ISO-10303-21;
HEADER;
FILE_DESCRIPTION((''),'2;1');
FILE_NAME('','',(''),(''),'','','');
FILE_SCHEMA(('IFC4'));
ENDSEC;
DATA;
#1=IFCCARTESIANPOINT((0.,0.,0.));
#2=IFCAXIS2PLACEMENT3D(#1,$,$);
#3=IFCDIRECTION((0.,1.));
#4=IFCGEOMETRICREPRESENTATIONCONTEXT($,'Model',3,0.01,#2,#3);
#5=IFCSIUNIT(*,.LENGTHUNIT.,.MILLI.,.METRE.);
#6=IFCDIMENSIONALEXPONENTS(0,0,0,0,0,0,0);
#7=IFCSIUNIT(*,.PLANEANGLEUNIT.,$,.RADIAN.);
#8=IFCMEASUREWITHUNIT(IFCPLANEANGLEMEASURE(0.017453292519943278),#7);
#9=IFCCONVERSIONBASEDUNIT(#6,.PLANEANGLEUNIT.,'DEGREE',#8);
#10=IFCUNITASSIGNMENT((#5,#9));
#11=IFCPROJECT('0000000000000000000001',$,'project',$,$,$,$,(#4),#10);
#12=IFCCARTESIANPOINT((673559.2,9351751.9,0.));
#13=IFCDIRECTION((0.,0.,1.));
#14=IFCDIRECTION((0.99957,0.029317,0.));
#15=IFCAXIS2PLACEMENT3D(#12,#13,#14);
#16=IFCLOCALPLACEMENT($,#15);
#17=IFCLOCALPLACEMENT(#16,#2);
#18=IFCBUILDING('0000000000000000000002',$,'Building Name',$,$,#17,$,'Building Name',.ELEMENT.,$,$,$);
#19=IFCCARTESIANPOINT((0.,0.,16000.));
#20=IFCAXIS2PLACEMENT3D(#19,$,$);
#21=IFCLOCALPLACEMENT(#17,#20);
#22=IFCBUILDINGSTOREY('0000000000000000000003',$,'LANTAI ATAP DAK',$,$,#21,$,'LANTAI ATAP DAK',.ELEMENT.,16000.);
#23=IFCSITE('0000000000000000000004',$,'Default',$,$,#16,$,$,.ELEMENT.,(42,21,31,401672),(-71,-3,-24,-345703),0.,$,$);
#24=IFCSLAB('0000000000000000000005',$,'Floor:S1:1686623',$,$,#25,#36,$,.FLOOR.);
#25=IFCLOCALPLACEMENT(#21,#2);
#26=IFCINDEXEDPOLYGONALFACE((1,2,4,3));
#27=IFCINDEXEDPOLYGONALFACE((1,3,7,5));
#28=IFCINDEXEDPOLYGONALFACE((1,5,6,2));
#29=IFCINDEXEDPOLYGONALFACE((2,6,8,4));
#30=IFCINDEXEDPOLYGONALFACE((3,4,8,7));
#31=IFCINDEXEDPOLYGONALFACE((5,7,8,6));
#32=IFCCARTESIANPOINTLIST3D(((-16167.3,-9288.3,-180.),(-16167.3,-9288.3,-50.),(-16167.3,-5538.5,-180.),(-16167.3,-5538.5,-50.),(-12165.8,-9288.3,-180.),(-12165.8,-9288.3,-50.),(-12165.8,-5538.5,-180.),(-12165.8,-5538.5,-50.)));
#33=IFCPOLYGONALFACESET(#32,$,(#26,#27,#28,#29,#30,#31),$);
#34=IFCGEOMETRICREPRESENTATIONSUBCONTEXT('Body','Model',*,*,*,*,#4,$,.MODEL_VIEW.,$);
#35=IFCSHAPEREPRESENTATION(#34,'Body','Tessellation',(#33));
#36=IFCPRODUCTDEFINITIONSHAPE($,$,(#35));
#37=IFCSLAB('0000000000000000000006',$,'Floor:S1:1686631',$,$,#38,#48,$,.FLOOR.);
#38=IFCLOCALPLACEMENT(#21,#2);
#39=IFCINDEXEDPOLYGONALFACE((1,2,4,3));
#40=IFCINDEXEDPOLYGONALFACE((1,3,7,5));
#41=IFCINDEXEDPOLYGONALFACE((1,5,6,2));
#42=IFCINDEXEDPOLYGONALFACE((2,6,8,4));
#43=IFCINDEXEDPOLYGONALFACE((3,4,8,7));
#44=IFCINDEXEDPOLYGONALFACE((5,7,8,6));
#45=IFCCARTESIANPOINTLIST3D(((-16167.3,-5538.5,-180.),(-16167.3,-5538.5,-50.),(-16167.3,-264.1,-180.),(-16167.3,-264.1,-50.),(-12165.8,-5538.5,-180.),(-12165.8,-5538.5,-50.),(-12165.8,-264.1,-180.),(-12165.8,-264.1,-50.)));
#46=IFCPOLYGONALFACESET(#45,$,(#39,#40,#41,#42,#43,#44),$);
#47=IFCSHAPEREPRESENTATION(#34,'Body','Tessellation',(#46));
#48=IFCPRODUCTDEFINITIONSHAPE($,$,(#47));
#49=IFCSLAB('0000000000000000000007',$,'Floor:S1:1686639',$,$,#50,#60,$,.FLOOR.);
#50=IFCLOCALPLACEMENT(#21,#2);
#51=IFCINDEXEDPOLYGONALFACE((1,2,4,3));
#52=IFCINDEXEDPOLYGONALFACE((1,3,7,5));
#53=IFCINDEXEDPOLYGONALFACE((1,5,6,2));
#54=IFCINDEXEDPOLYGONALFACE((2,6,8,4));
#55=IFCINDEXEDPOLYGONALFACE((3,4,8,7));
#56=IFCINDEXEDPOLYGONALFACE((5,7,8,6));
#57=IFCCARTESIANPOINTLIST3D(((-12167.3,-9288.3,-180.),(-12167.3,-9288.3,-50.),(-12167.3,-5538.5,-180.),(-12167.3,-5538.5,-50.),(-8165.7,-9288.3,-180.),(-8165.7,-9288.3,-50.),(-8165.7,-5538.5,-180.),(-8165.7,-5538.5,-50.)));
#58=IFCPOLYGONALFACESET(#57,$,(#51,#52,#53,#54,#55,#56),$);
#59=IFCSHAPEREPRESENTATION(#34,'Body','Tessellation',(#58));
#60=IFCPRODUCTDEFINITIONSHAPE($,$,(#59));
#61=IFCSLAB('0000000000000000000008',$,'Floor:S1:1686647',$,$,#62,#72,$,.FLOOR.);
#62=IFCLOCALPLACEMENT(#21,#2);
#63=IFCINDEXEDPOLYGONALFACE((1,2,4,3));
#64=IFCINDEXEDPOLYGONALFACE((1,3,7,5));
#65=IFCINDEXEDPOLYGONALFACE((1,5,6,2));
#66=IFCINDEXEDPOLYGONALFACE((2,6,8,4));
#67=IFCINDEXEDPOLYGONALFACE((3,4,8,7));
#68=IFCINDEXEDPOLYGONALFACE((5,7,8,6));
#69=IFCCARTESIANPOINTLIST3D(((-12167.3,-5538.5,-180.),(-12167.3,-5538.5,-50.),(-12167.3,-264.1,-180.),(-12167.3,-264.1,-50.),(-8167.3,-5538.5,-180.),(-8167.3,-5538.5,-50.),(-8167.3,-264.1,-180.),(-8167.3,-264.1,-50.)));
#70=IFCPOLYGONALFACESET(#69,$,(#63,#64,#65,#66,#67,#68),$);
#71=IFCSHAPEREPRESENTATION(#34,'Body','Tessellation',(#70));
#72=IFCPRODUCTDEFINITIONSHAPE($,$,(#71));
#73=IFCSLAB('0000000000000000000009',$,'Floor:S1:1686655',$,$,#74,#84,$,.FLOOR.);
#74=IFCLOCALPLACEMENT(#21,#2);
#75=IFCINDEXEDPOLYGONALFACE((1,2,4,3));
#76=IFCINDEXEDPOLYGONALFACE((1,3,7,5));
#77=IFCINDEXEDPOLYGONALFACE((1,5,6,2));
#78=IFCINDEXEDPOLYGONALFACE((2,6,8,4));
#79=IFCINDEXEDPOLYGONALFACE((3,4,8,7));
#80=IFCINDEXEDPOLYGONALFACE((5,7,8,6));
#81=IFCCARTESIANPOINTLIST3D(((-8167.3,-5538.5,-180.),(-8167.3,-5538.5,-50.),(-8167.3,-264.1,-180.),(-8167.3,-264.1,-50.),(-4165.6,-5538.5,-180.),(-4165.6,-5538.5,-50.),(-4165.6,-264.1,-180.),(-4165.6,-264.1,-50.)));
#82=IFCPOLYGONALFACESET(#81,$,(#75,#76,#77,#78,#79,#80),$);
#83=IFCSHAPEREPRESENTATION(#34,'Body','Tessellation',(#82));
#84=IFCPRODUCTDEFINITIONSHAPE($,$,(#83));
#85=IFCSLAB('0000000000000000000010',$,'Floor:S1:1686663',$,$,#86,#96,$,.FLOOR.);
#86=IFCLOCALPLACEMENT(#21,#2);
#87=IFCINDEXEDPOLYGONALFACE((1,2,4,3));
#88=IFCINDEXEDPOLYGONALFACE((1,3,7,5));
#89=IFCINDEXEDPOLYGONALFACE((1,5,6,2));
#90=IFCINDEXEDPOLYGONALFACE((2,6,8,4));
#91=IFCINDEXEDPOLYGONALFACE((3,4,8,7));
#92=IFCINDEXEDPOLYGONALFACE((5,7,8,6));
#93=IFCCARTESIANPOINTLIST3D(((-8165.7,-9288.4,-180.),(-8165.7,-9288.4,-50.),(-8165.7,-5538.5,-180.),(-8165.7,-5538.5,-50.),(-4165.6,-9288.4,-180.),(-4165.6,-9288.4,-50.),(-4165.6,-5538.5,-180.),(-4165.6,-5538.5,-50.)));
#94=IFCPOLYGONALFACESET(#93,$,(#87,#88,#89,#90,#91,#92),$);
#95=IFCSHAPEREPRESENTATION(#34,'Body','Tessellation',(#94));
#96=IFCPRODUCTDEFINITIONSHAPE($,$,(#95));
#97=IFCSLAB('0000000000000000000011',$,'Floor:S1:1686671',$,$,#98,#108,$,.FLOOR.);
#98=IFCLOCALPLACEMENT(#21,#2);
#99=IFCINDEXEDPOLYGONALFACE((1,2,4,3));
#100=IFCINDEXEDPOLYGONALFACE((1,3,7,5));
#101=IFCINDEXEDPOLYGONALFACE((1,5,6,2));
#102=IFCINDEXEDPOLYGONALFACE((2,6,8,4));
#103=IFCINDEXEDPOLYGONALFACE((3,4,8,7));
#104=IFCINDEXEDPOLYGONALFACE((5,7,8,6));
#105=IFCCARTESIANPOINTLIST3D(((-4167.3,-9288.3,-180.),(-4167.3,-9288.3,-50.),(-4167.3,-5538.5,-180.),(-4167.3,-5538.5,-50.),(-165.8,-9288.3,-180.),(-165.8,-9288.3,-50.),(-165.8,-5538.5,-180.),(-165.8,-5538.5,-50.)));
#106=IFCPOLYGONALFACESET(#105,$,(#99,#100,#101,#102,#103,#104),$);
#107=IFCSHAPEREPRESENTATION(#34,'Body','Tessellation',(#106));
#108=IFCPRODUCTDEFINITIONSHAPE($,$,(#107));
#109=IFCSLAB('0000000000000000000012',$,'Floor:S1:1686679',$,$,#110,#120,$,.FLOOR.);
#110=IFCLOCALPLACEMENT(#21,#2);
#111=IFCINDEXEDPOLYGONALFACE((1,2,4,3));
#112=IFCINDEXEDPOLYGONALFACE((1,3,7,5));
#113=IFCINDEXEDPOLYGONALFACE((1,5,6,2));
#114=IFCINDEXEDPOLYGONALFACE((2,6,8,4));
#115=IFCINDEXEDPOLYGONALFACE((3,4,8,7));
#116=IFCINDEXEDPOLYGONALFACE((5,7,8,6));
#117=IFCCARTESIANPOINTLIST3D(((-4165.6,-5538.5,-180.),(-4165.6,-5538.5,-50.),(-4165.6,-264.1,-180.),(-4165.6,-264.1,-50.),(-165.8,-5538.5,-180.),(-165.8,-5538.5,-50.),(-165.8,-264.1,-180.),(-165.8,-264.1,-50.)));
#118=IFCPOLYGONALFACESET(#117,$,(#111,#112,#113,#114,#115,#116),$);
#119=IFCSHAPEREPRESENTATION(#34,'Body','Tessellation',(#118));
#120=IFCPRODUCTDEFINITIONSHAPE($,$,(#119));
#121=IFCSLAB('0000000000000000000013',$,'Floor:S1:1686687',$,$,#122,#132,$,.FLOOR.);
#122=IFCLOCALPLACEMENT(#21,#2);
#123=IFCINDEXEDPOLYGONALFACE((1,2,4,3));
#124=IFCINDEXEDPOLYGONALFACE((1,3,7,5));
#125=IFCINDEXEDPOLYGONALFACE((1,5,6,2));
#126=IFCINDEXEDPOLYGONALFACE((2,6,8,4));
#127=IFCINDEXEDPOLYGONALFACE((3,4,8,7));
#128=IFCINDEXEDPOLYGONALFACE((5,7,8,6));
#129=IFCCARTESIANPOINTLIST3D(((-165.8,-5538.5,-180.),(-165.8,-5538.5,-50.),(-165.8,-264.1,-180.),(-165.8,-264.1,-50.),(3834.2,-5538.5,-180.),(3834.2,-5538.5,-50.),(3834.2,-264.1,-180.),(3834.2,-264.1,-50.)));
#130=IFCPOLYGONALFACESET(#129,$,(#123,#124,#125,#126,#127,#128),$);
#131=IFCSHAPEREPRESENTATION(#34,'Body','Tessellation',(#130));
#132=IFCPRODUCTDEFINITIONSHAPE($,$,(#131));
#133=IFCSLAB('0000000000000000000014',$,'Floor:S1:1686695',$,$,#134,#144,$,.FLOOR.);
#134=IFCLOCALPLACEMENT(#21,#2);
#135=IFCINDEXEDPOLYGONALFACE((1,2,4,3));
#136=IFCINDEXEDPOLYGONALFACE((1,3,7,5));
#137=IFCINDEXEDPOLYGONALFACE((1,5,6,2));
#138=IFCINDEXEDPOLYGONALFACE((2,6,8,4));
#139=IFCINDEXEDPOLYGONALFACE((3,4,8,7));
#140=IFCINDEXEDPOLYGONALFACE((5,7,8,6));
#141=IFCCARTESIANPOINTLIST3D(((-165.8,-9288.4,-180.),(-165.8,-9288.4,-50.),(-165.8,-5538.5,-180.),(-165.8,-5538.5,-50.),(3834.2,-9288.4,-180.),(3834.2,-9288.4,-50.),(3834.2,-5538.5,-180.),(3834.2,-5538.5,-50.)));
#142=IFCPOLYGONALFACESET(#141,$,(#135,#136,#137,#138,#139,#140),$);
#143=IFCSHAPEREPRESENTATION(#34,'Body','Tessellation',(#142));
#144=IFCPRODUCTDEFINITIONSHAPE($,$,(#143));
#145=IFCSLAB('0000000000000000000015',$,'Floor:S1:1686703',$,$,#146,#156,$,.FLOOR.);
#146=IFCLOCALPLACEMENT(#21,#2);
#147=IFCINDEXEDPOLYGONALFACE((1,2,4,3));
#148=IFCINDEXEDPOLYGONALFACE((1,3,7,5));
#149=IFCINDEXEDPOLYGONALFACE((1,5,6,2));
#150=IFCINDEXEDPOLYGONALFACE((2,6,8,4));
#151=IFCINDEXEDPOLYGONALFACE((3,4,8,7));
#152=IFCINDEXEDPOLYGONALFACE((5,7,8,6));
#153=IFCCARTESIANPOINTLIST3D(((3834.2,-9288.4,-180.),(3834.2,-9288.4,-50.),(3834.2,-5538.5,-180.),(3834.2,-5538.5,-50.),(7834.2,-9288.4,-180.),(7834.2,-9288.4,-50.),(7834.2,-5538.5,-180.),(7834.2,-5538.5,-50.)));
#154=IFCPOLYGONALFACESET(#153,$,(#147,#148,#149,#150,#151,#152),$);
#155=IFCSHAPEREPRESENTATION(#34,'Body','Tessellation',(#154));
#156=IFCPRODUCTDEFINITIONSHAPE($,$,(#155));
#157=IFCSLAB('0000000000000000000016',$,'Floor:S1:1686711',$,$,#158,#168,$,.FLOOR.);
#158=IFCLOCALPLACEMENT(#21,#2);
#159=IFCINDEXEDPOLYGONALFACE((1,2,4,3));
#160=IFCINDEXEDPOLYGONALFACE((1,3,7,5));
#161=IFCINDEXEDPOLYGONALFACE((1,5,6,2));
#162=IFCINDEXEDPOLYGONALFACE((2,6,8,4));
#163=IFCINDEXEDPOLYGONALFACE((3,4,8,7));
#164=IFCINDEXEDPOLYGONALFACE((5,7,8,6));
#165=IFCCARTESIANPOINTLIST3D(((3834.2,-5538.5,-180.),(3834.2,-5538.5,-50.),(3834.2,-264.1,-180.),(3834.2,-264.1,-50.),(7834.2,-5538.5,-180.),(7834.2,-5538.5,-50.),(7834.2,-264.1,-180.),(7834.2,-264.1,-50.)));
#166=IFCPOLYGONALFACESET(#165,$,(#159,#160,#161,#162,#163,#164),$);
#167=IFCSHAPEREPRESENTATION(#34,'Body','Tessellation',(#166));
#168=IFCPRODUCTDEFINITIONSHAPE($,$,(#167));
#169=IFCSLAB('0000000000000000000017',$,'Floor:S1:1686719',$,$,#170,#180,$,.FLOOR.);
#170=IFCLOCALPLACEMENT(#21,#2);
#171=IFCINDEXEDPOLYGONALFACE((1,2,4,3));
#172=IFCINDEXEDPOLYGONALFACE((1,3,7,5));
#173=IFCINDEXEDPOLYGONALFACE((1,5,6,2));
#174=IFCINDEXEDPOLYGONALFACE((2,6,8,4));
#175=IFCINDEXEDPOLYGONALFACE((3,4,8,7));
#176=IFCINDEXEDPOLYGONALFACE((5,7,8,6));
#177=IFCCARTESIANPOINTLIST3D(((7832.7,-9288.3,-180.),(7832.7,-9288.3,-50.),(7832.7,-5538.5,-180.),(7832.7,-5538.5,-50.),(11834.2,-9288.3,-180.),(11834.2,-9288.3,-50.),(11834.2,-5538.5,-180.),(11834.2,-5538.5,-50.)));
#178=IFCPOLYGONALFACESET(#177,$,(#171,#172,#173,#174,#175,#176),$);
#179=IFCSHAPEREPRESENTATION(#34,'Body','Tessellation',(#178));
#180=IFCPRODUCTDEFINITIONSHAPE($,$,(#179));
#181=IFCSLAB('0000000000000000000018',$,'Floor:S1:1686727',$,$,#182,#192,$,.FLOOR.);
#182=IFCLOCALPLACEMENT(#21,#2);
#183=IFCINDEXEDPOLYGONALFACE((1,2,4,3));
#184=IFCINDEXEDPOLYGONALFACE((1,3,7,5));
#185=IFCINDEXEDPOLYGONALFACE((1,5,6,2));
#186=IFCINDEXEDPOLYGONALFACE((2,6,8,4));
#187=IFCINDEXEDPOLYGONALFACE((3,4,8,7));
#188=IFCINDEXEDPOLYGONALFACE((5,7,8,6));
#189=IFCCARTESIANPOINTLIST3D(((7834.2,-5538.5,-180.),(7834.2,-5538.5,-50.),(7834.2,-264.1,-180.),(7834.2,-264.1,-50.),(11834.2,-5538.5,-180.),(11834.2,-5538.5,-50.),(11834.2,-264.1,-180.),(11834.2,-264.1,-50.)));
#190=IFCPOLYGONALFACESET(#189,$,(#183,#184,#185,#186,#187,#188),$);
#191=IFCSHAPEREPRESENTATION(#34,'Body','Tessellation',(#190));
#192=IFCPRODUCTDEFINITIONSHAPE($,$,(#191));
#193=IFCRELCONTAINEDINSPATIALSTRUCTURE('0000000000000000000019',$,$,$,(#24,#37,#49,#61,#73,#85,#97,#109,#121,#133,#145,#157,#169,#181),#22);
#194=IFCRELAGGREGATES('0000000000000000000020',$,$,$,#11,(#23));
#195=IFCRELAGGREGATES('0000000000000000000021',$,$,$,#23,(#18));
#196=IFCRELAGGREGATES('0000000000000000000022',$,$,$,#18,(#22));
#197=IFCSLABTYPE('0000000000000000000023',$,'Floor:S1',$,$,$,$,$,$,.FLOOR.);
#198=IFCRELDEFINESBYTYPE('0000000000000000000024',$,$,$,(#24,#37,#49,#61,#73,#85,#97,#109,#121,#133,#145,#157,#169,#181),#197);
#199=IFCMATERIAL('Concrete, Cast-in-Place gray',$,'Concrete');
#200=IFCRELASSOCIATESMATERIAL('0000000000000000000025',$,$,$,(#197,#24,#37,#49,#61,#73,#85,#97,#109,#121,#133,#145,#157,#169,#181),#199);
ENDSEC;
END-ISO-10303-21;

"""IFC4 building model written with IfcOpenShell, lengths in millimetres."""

from ifc_helpers import new_model, entity, si_unit, converted_unit, direction, frame, origin, place, context, subcontext, project, spatial, indexed_curve, outline, extrude, material, type_object, element, save


model = new_model("IFC4")

# Units and contexts
model_context = context("Model", 3, precision=0.01, world=origin(), true_north=direction((0.0, 1.0)))
body_context = subcontext(model_context, "Body", "Model", "MODEL_VIEW")
ifc_project = project(units=[si_unit("LENGTHUNIT", "METRE", prefix="MILLI"), converted_unit("PLANEANGLEUNIT", "DEGREE", entity("IfcPlaneAngleMeasure", 0.017453292519943278), si_unit("PLANEANGLEUNIT", "RADIAN"), dimensions=[0, 0, 0, 0, 0, 0, 0])], contexts=[model_context])

# Site, building, storey
site_placement = place(None, frame((673559.2, 9351751.9, 0.0), z_axis=(0.0, 0.0, 1.0), x_axis=(0.99957, 0.029317, 0.0)))
site = spatial("IfcSite", under=ifc_project, at=site_placement, Name="Default", CompositionType="ELEMENT", RefLatitude=(42, 21, 31, 401672), RefLongitude=(-71, -3, -24, -345703), RefElevation=0.0)
building_placement = place(site_placement, origin())
building = spatial("IfcBuilding", under=site, at=building_placement, Name="Building Name", LongName="Building Name", CompositionType="ELEMENT")
storey_placement = place(building_placement, frame((0.0, 0.0, 16000.0)))
storey = spatial("IfcBuildingStorey", under=building, at=storey_placement, Name="LANTAI ATAP DAK", LongName="LANTAI ATAP DAK", CompositionType="ELEMENT", Elevation=16000.0)

# Slabs
ifc_material = material(Name="Concrete, Cast-in-Place gray", Category="Concrete")
slab_type_1 = type_object("IfcSlabType", Name="Floor:S1", PredefinedType="FLOOR", material=ifc_material)
slab_1_placement = place(storey_placement, origin())
element("IfcSlab", 1, at=slab_1_placement, inside=storey, type_object=slab_type_1, material=ifc_material, Name="Floor:S1:1686623", PredefinedType="FLOOR", context=body_context, shape_type="SweptSolid", body=[
    extrude(outline(indexed_curve([(-1874.9, -2000.8), (1874.9, -2000.8), (1874.9, 2000.8), (-1874.9, 2000.8), (-1874.9, -2000.8)], self_intersect=False)), frame((-14166.6, -7413.4, -50.0), z_axis=(0.0, 0.0, -1.0), x_axis=(0.0, 1.0, 0.0)), (0.0, 0.0, 1.0), 130.0),
])
slab_2_placement = place(storey_placement, origin())
element("IfcSlab", 2, at=slab_2_placement, inside=storey, type_object=slab_type_1, material=ifc_material, Name="Floor:S1:1686631", PredefinedType="FLOOR", context=body_context, shape_type="SweptSolid", body=[
    extrude(outline(indexed_curve([(-2637.2, -2000.8), (2637.2, -2000.8), (2637.2, 2000.8), (-2637.2, 2000.8), (-2637.2, -2000.8)], self_intersect=False)), frame((-14166.6, -2901.3, -50.0), z_axis=(0.0, 0.0, -1.0), x_axis=(0.0, 1.0, 0.0)), (0.0, 0.0, 1.0), 130.0),
])
slab_3_placement = place(storey_placement, origin())
element("IfcSlab", 3, at=slab_3_placement, inside=storey, type_object=slab_type_1, material=ifc_material, Name="Floor:S1:1686639", PredefinedType="FLOOR", context=body_context, shape_type="SweptSolid", body=[
    extrude(outline(indexed_curve([(-1874.9, -2000.8), (1874.9, -2000.8), (1874.9, 2000.8), (-1874.9, 2000.8), (-1874.9, -2000.8)], self_intersect=False)), frame((-10166.5, -7413.4, -50.0), z_axis=(0.0, 0.0, -1.0), x_axis=(0.0, 1.0, 0.0)), (0.0, 0.0, 1.0), 130.0),
])
slab_4_placement = place(storey_placement, origin())
element("IfcSlab", 4, at=slab_4_placement, inside=storey, type_object=slab_type_1, material=ifc_material, Name="Floor:S1:1686647", PredefinedType="FLOOR", context=body_context, shape_type="SweptSolid", body=[
    extrude(outline(indexed_curve([(-2637.2, -2000.0), (2637.2, -2000.0), (2637.2, 2000.0), (-2637.2, 2000.0), (-2637.2, -2000.0)], self_intersect=False)), frame((-10167.3, -2901.3, -50.0), z_axis=(0.0, 0.0, -1.0), x_axis=(0.0, 1.0, 0.0)), (0.0, 0.0, 1.0), 130.0),
])
slab_5_placement = place(storey_placement, origin())
element("IfcSlab", 5, at=slab_5_placement, inside=storey, type_object=slab_type_1, material=ifc_material, Name="Floor:S1:1686655", PredefinedType="FLOOR", context=body_context, shape_type="SweptSolid", body=[
    extrude(outline(indexed_curve([(-2637.2, -2000.9), (2637.2, -2000.9), (2637.2, 2000.9), (-2637.2, 2000.9), (-2637.2, -2000.9)], self_intersect=False)), frame((-6166.4, -2901.3, -50.0), z_axis=(0.0, 0.0, -1.0), x_axis=(0.0, 1.0, 0.0)), (0.0, 0.0, 1.0), 130.0),
])
slab_6_placement = place(storey_placement, origin())
element("IfcSlab", 6, at=slab_6_placement, inside=storey, type_object=slab_type_1, material=ifc_material, Name="Floor:S1:1686663", PredefinedType="FLOOR", context=body_context, shape_type="SweptSolid", body=[
    extrude(outline(indexed_curve([(-1874.9, -2000.1), (1874.9, -2000.1), (1874.9, 2000.1), (-1874.9, 2000.1), (-1874.9, -2000.1)], self_intersect=False)), frame((-6165.6, -7413.5, -50.0), z_axis=(0.0, 0.0, -1.0), x_axis=(0.0, 1.0, 0.0)), (0.0, 0.0, 1.0), 130.0),
])
slab_7_placement = place(storey_placement, origin())
element("IfcSlab", 7, at=slab_7_placement, inside=storey, type_object=slab_type_1, material=ifc_material, Name="Floor:S1:1686671", PredefinedType="FLOOR", context=body_context, shape_type="SweptSolid", body=[
    extrude(outline(indexed_curve([(-1874.9, -2000.8), (1874.9, -2000.8), (1874.9, 2000.8), (-1874.9, 2000.8), (-1874.9, -2000.8)], self_intersect=False)), frame((-2166.6, -7413.4, -50.0), z_axis=(0.0, 0.0, -1.0), x_axis=(0.0, 1.0, 0.0)), (0.0, 0.0, 1.0), 130.0),
])
slab_8_placement = place(storey_placement, origin())
element("IfcSlab", 8, at=slab_8_placement, inside=storey, type_object=slab_type_1, material=ifc_material, Name="Floor:S1:1686679", PredefinedType="FLOOR", context=body_context, shape_type="SweptSolid", body=[
    extrude(outline(indexed_curve([(-2637.2, -1999.9), (2637.2, -1999.9), (2637.2, 1999.9), (-2637.2, 1999.9), (-2637.2, -1999.9)], self_intersect=False)), frame((-2165.7, -2901.3, -50.0), z_axis=(0.0, 0.0, -1.0), x_axis=(0.0, 1.0, 0.0)), (0.0, 0.0, 1.0), 130.0),
])
slab_9_placement = place(storey_placement, origin())
element("IfcSlab", 9, at=slab_9_placement, inside=storey, type_object=slab_type_1, material=ifc_material, Name="Floor:S1:1686687", PredefinedType="FLOOR", context=body_context, shape_type="SweptSolid", body=[
    extrude(outline(indexed_curve([(-2637.2, -2000.0), (2637.2, -2000.0), (2637.2, 2000.0), (-2637.2, 2000.0), (-2637.2, -2000.0)], self_intersect=False)), frame((1834.2, -2901.3, -50.0), z_axis=(0.0, 0.0, -1.0), x_axis=(0.0, 1.0, 0.0)), (0.0, 0.0, 1.0), 130.0),
])
slab_10_placement = place(storey_placement, origin())
element("IfcSlab", 10, at=slab_10_placement, inside=storey, type_object=slab_type_1, material=ifc_material, Name="Floor:S1:1686695", PredefinedType="FLOOR", context=body_context, shape_type="SweptSolid", body=[
    extrude(outline(indexed_curve([(-1874.9, -2000.0), (1874.9, -2000.0), (1874.9, 2000.0), (-1874.9, 2000.0), (-1874.9, -2000.0)], self_intersect=False)), frame((1834.2, -7413.5, -50.0), z_axis=(0.0, 0.0, -1.0), x_axis=(0.0, 1.0, 0.0)), (0.0, 0.0, 1.0), 130.0),
])
slab_11_placement = place(storey_placement, origin())
element("IfcSlab", 11, at=slab_11_placement, inside=storey, type_object=slab_type_1, material=ifc_material, Name="Floor:S1:1686703", PredefinedType="FLOOR", context=body_context, shape_type="SweptSolid", body=[
    extrude(outline(indexed_curve([(-1874.9, -2000.0), (1874.9, -2000.0), (1874.9, 2000.0), (-1874.9, 2000.0), (-1874.9, -2000.0)], self_intersect=False)), frame((5834.2, -7413.5, -50.0), z_axis=(0.0, 0.0, -1.0), x_axis=(0.0, 1.0, 0.0)), (0.0, 0.0, 1.0), 130.0),
])
slab_12_placement = place(storey_placement, origin())
element("IfcSlab", 12, at=slab_12_placement, inside=storey, type_object=slab_type_1, material=ifc_material, Name="Floor:S1:1686711", PredefinedType="FLOOR", context=body_context, shape_type="SweptSolid", body=[
    extrude(outline(indexed_curve([(-2637.2, -2000.0), (2637.2, -2000.0), (2637.2, 2000.0), (-2637.2, 2000.0), (-2637.2, -2000.0)], self_intersect=False)), frame((5834.2, -2901.3, -50.0), z_axis=(0.0, 0.0, -1.0), x_axis=(0.0, 1.0, 0.0)), (0.0, 0.0, 1.0), 130.0),
])
slab_13_placement = place(storey_placement, origin())
element("IfcSlab", 13, at=slab_13_placement, inside=storey, type_object=slab_type_1, material=ifc_material, Name="Floor:S1:1686719", PredefinedType="FLOOR", context=body_context, shape_type="SweptSolid", body=[
    extrude(outline(indexed_curve([(-1874.9, -2000.7), (1874.9, -2000.7), (1874.9, 2000.7), (-1874.9, 2000.7), (-1874.9, -2000.7)], self_intersect=False)), frame((9833.4, -7413.4, -50.0), z_axis=(0.0, 0.0, -1.0), x_axis=(0.0, 1.0, 0.0)), (0.0, 0.0, 1.0), 130.0),
])
slab_14_placement = place(storey_placement, origin())
element("IfcSlab", 14, at=slab_14_placement, inside=storey, type_object=slab_type_1, material=ifc_material, Name="Floor:S1:1686727", PredefinedType="FLOOR", context=body_context, shape_type="SweptSolid", body=[
    extrude(outline(indexed_curve([(-2637.2, -2000.0), (2637.2, -2000.0), (2637.2, 2000.0), (-2637.2, 2000.0), (-2637.2, -2000.0)], self_intersect=False)), frame((9834.2, -2901.3, -50.0), z_axis=(0.0, 0.0, -1.0), x_axis=(0.0, 1.0, 0.0)), (0.0, 0.0, 1.0), 130.0),
])

save(model, "model.ifc")
